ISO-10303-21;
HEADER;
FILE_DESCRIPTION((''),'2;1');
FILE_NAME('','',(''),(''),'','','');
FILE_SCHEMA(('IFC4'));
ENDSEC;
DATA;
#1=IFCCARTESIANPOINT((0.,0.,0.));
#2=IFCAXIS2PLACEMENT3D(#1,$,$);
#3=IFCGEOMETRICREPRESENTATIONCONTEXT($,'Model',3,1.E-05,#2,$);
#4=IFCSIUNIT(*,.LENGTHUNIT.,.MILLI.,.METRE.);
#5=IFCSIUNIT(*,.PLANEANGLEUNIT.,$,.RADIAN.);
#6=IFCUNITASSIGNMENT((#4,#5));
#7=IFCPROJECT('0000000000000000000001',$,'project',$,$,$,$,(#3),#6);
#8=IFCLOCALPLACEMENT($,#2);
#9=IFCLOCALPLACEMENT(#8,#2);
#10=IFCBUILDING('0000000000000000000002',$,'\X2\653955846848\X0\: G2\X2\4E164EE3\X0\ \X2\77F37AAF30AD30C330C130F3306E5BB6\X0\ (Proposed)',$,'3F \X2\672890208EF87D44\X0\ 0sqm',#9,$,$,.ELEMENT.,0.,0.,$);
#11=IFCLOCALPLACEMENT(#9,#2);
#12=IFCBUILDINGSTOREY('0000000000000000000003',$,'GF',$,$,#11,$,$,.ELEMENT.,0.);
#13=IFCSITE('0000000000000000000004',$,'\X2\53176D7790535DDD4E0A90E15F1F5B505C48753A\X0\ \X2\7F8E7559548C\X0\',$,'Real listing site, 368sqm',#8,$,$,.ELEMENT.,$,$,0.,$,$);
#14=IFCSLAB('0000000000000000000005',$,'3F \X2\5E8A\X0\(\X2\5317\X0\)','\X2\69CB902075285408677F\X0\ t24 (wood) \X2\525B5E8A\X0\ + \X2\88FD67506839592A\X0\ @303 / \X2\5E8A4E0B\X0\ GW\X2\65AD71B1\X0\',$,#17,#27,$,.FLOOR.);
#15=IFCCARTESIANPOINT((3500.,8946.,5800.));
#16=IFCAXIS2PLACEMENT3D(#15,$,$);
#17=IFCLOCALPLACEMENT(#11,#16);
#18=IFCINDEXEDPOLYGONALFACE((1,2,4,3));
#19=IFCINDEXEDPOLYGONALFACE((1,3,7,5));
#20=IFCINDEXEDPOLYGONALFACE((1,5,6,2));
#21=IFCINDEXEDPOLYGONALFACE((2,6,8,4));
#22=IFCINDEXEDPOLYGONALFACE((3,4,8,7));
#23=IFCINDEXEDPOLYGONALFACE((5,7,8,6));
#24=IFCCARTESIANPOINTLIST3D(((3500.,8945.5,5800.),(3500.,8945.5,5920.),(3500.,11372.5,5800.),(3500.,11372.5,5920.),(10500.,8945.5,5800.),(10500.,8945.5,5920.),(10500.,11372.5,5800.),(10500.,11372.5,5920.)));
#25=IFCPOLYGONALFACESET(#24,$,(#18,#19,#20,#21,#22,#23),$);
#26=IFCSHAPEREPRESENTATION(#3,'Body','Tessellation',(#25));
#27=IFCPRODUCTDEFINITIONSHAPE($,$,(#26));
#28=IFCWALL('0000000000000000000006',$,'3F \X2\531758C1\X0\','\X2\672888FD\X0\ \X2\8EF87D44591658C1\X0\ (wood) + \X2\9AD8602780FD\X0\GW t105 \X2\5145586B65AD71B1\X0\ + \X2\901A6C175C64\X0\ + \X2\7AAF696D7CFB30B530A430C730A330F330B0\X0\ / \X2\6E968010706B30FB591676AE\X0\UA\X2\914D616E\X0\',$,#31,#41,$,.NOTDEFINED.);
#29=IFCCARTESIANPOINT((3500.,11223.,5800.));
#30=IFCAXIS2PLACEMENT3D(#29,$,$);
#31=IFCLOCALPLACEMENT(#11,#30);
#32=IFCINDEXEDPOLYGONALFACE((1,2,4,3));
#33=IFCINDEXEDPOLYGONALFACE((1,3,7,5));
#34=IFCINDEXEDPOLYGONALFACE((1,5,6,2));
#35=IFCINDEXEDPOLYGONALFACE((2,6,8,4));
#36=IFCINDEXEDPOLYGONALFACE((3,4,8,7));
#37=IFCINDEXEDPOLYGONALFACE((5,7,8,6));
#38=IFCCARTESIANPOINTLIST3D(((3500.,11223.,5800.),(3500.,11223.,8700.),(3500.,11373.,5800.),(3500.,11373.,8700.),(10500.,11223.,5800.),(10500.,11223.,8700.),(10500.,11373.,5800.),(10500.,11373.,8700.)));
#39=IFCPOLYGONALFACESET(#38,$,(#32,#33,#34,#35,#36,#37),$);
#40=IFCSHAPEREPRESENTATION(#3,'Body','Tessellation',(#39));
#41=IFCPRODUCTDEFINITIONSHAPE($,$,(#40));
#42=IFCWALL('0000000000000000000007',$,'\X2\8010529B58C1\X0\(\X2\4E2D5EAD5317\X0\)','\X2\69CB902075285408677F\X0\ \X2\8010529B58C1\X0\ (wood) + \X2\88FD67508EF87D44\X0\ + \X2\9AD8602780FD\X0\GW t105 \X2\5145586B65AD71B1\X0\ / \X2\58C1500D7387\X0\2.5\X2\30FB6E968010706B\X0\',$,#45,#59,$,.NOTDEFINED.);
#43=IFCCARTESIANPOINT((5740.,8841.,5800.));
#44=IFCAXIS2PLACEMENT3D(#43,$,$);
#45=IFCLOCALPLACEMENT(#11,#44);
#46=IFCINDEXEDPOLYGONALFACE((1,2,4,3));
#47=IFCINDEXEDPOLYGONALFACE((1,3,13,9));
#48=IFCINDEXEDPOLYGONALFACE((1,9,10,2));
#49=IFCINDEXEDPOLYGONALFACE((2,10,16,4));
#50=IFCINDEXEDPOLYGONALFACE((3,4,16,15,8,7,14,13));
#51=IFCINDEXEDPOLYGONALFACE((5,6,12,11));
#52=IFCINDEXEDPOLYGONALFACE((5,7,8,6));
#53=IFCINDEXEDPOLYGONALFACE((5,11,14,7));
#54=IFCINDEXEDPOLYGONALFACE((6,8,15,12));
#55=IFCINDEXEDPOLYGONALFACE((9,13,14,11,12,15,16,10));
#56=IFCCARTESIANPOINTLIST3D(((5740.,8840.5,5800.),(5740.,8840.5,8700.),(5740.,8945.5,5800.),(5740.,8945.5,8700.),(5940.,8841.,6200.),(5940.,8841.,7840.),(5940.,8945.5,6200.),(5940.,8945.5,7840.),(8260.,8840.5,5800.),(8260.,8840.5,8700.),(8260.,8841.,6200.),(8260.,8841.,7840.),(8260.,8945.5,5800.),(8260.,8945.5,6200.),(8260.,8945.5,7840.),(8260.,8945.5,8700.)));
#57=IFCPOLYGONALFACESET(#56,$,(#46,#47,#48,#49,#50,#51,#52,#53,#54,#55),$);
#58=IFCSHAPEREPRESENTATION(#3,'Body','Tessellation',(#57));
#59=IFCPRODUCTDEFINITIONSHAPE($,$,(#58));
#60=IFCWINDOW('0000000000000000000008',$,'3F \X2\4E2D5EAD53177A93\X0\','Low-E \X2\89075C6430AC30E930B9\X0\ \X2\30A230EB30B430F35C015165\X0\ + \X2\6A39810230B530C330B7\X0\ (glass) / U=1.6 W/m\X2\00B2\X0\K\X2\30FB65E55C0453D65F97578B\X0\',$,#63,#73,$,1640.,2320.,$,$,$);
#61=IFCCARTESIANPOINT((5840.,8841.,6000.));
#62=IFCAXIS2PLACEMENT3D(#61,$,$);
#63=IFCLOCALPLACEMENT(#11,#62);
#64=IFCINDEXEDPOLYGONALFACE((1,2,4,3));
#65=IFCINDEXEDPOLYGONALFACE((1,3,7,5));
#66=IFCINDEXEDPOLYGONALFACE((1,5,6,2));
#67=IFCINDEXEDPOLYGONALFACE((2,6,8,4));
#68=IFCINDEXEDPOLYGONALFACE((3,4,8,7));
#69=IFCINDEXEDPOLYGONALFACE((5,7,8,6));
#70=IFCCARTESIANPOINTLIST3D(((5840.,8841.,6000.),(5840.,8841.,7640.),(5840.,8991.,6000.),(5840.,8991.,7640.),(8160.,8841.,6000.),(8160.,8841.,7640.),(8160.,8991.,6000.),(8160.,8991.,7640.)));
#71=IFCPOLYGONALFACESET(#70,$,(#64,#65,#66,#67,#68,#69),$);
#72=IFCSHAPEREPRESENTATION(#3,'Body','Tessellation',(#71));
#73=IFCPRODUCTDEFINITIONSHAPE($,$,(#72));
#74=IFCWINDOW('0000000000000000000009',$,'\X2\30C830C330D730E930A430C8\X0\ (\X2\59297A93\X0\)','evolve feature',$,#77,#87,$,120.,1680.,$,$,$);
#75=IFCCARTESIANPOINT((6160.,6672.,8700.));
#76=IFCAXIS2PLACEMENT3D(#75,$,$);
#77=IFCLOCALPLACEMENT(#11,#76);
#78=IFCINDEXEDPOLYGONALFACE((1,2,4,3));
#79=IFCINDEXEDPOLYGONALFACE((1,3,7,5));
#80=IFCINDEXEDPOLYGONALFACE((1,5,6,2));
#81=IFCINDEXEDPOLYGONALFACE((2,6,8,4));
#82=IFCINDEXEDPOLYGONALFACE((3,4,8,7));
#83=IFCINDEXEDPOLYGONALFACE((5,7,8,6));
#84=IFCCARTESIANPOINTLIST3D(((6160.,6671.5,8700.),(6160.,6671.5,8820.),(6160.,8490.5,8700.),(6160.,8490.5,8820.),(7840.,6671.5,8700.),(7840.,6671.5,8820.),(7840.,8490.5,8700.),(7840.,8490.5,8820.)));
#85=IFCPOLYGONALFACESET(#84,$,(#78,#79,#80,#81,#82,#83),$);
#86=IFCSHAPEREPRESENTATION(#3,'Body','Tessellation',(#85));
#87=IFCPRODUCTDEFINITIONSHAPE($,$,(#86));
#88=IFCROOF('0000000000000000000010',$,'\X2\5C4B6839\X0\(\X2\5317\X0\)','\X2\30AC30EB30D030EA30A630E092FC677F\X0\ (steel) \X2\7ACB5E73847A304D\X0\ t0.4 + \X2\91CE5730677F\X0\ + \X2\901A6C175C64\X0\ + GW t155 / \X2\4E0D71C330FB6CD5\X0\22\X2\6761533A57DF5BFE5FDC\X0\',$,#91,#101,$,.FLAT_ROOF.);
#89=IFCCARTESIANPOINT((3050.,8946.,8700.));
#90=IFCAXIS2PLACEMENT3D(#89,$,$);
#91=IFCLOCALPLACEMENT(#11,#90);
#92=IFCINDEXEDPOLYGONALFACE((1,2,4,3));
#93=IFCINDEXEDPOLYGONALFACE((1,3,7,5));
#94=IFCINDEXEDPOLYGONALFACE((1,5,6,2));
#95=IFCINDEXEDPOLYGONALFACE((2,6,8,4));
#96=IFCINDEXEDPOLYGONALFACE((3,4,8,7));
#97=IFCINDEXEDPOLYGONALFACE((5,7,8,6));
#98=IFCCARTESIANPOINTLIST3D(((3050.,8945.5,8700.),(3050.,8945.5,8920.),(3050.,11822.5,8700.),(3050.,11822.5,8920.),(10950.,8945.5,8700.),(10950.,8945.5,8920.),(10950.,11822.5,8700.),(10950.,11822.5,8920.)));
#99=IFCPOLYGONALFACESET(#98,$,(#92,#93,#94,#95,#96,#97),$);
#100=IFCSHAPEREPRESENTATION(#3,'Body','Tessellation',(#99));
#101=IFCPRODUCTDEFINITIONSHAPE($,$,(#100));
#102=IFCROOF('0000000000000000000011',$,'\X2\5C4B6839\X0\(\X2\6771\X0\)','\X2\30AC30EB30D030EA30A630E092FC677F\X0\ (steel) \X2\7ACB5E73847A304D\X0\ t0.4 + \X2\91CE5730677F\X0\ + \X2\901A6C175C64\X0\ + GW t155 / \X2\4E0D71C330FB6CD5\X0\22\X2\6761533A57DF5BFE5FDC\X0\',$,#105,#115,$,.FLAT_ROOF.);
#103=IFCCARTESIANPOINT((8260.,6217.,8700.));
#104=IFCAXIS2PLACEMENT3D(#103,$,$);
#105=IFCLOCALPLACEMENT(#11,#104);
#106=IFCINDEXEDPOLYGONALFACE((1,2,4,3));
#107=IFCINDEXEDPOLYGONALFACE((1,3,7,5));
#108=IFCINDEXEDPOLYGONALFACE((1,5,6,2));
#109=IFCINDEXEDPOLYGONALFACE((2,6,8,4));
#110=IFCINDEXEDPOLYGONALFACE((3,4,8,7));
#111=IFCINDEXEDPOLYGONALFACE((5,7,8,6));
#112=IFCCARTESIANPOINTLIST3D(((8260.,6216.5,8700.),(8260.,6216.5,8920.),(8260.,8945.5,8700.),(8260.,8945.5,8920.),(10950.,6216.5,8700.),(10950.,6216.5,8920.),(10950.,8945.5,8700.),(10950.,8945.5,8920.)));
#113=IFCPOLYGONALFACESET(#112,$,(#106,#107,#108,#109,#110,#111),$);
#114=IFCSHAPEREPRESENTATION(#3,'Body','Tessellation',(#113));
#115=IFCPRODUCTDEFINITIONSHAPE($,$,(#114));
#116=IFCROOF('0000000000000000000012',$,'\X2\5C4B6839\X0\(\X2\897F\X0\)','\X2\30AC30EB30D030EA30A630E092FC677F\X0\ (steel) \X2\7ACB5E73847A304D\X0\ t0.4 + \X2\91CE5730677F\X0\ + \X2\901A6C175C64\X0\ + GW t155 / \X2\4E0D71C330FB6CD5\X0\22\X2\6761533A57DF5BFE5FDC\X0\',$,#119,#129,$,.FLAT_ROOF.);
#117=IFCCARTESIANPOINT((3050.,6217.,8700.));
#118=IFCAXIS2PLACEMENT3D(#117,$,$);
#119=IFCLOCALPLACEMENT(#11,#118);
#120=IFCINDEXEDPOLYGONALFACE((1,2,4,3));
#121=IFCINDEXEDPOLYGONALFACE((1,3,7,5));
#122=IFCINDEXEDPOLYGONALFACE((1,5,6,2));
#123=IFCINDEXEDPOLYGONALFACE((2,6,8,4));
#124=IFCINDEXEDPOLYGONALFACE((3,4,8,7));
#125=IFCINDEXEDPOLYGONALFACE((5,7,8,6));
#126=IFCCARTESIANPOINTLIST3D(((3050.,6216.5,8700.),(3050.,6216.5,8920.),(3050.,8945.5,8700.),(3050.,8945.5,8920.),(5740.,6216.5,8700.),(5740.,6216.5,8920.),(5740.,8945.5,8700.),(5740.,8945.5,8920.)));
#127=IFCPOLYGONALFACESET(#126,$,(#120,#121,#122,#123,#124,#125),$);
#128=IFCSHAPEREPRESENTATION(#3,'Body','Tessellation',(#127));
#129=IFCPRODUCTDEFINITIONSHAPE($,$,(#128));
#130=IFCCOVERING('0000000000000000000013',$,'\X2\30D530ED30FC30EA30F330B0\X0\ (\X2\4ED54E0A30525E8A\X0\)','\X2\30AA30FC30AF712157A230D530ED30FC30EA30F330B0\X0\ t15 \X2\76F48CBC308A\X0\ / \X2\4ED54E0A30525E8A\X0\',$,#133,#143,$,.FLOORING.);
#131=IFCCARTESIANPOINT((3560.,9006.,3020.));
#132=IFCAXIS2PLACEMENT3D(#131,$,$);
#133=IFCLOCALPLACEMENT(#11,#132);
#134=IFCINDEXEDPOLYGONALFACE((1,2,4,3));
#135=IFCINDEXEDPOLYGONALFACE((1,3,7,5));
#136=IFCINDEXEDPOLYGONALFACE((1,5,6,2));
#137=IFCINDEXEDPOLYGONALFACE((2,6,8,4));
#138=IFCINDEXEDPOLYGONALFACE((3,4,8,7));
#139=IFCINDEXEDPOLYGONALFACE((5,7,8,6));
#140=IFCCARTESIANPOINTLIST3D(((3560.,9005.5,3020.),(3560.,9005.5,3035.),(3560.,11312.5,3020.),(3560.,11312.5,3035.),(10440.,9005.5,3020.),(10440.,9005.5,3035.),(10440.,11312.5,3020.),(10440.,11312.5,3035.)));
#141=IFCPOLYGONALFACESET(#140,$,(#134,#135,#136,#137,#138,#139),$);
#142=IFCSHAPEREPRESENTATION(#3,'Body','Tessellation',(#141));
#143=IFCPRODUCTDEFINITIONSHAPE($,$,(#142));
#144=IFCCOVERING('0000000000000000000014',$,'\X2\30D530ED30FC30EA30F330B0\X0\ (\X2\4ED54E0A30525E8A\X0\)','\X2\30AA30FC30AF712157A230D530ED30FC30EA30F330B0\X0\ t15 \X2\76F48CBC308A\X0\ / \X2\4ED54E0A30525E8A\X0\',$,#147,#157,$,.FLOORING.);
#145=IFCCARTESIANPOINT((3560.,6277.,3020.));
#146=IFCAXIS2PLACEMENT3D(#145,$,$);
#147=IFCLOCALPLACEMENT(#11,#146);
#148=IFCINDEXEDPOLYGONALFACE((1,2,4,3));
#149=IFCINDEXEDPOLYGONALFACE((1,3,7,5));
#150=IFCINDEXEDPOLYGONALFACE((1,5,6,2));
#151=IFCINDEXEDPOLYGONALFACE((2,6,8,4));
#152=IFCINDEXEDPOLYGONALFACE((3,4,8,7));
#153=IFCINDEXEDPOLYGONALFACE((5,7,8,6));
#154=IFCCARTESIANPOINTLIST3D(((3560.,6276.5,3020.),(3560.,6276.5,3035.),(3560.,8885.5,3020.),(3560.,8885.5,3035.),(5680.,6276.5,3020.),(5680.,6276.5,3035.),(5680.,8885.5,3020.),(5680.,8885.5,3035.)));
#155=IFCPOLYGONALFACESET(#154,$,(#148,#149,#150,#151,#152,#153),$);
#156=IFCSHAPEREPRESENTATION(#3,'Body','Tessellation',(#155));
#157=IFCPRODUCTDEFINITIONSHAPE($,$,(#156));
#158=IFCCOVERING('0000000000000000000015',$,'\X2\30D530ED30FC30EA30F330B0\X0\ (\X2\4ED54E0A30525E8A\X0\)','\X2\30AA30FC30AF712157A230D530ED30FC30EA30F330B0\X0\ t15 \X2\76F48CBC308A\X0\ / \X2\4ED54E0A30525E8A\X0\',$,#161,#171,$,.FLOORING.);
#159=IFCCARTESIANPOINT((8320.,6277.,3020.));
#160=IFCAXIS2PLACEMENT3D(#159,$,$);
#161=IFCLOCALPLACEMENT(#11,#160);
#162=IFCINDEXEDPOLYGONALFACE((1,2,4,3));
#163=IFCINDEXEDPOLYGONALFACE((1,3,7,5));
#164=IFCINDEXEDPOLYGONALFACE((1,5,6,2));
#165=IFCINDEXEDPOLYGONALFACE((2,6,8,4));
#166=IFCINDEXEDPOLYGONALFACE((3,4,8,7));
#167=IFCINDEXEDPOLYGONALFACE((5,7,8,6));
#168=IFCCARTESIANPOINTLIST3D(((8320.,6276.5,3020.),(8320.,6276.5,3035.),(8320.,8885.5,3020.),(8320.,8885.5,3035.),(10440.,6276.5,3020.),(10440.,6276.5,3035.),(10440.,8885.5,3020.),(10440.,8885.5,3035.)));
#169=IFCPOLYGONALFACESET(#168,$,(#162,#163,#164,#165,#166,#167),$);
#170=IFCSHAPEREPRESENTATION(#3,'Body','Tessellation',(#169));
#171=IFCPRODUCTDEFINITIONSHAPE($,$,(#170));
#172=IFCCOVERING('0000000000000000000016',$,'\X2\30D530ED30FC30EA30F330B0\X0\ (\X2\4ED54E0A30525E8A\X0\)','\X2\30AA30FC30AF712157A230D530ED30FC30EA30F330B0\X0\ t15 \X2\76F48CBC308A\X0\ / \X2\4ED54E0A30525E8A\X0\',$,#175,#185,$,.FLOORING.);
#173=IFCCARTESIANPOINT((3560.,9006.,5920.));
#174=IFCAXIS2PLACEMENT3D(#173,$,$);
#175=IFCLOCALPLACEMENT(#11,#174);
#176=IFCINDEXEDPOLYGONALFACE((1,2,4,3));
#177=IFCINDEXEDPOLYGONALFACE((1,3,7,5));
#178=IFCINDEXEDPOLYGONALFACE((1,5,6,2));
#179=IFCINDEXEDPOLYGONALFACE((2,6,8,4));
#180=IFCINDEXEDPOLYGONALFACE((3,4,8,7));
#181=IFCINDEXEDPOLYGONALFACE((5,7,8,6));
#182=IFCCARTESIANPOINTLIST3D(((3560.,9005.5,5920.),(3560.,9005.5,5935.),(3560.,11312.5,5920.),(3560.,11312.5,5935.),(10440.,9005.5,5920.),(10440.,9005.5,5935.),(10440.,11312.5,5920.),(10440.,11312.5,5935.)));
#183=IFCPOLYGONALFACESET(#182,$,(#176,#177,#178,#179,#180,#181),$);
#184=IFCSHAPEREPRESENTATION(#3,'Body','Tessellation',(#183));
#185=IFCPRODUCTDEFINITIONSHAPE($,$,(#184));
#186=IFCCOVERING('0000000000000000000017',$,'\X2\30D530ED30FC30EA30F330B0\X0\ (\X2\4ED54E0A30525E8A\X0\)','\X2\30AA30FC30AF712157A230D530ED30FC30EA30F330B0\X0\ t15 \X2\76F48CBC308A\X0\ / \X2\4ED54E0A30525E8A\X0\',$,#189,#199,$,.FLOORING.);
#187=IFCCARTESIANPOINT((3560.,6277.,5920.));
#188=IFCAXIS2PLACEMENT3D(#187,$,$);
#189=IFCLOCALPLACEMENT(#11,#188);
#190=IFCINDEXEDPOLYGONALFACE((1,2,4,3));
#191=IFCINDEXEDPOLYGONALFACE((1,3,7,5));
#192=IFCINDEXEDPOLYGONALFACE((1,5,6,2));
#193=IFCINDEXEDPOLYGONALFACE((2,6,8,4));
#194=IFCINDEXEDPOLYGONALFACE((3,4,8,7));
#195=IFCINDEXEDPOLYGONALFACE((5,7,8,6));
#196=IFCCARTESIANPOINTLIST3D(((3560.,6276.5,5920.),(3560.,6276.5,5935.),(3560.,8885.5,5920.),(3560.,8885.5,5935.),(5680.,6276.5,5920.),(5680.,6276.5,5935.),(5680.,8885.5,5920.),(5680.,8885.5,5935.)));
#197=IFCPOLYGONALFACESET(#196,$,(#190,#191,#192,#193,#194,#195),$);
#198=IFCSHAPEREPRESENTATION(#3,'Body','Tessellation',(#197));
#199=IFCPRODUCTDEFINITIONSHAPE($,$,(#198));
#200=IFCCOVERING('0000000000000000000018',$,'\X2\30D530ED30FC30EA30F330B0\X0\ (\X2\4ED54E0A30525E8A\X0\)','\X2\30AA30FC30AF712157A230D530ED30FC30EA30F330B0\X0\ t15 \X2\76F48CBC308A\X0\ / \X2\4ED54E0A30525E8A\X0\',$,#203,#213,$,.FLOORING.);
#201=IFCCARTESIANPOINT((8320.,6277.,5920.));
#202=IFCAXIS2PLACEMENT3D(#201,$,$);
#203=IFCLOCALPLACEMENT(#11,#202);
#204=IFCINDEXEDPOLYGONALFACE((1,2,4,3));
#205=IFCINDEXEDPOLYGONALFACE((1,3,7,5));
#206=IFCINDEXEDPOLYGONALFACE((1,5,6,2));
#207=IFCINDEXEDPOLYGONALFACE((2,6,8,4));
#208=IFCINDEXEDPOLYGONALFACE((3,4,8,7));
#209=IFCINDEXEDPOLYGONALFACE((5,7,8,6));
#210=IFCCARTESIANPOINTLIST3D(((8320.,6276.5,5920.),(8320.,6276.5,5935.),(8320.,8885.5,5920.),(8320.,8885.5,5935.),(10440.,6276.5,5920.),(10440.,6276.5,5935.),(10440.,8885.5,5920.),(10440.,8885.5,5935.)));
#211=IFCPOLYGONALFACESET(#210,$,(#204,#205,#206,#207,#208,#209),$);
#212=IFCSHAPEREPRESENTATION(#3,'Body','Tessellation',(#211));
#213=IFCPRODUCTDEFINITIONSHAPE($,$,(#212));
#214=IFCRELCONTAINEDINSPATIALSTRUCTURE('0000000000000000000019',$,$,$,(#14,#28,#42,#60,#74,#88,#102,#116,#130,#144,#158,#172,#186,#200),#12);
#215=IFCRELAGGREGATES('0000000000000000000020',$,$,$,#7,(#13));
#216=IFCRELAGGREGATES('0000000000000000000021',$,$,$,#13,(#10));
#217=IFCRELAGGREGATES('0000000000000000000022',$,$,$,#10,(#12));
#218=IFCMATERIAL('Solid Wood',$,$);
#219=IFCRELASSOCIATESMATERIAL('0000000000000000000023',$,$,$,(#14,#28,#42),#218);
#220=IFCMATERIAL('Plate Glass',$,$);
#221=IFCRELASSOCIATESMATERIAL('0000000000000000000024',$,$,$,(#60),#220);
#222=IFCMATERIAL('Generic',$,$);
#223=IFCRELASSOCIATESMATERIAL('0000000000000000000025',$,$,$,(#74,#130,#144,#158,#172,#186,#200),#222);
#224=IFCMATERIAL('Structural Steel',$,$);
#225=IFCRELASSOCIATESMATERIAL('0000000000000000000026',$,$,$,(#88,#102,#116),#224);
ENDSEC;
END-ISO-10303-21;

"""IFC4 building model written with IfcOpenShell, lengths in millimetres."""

from ifc_helpers import new_model, si_unit, frame, frame_2d, origin, place, context, project, spatial, rectangle, extrude, material, element, fill, save


model = new_model("IFC4")

# Units and contexts
model_context = context("Model", 3, precision=1e-05, world=origin())
ifc_project = project(units=[si_unit("LENGTHUNIT", "METRE", prefix="MILLI"), si_unit("PLANEANGLEUNIT", "RADIAN")], contexts=[model_context])

# Site, building, storey
site_placement = place(None, origin())
site = spatial("IfcSite", under=ifc_project, at=site_placement, Name="北海道川上郡弟子屈町 美留和", ObjectType="Real listing site, 368sqm", CompositionType="ELEMENT", RefElevation=0.0)
building_placement = place(site_placement, origin())
building = spatial("IfcBuilding", under=site, at=building_placement, Name="改善案: G2世代 石窯キッチンの家 (Proposed)", ObjectType="3F 木造軸組 0sqm", CompositionType="ELEMENT", ElevationOfRefHeight=0.0, ElevationOfTerrain=0.0)
storey_placement = place(building_placement, origin())
storey = spatial("IfcBuildingStorey", under=building, at=storey_placement, Name="GF", CompositionType="ELEMENT", Elevation=0.0)

# Slab
ifc_material_1 = material(Name="Solid Wood")
slab_placement = place(storey_placement, frame((3500.0, 8946.0, 5800.0)))
element("IfcSlab", 1, at=slab_placement, inside=storey, material=ifc_material_1, Name="3F 床(北)", Description="構造用合板 t24 (wood) 剛床 + 製材根太 @303 / 床下 GW断熱", PredefinedType="FLOOR", context=model_context, shape_type="SweptSolid", body=[
    extrude(rectangle(XDim=7000.0, YDim=2427.0, at=frame_2d((3500.0, 1213.0))), frame((3500.0, 8946.0, 5800.0)), (0.0, 0.0, 1.0), 120.0),
])

# Wall
wall_1_placement = place(storey_placement, frame((3500.0, 11223.0, 5800.0)))
element("IfcWall", 2, at=wall_1_placement, inside=storey, material=ifc_material_1, Name="3F 北壁", Description="木製 軸組外壁 (wood) + 高性能GW t105 充填断熱 + 通気層 + 窯業系サイディング / 準耐火・外皮UA配慮", PredefinedType="NOTDEFINED", context=model_context, shape_type="SweptSolid", body=[
    extrude(rectangle(XDim=7000.0, YDim=150.0, at=frame_2d((3500.0, 75.0))), frame((3500.0, 11223.0, 5800.0)), (0.0, 0.0, 1.0), 2900.0),
])

# Wall, opening, window
wall_2_placement = place(storey_placement, frame((5740.0, 8841.0, 5800.0)))
wall_2 = element("IfcWall", 3, at=wall_2_placement, inside=storey, material=ifc_material_1, Name="耐力壁(中庭北)", Description="構造用合板 耐力壁 (wood) + 製材軸組 + 高性能GW t105 充填断熱 / 壁倍率2.5・準耐火", PredefinedType="NOTDEFINED", context=model_context, shape_type="SweptSolid", body=[
    extrude(rectangle(XDim=2520.0, YDim=105.0, at=frame_2d((1260.0, 52.0))), frame((5740.0, 8841.0, 5800.0)), (0.0, 0.0, 1.0), 2900.0),
])
opening_placement = place(storey_placement, frame((5840.0, 8841.0, 6000.0)))
opening = element("IfcOpeningElement", 4, at=opening_placement, cuts=wall_2, PredefinedType="NOTDEFINED", context=model_context, shape_type="SweptSolid", body=[
    extrude(rectangle(XDim=2320.0, YDim=150.0, at=frame_2d((1160.0, 75.0))), frame((5840.0, 8841.0, 6000.0)), (0.0, 0.0, 1.0), 1640.0),
])
ifc_material_2 = material(Name="Plate Glass")
window_1_placement = place(storey_placement, frame((5840.0, 8841.0, 6000.0)))
window_1 = element("IfcWindow", 5, at=window_1_placement, inside=storey, material=ifc_material_2, Name="3F 中庭北窓", Description="Low-E 複層ガラス アルゴン封入 + 樹脂サッシ (glass) / U=1.6 W/m²K・日射取得型", OverallHeight=1640.0, OverallWidth=2320.0, context=model_context, shape_type="SweptSolid", body=[
    extrude(rectangle(XDim=2320.0, YDim=150.0, at=frame_2d((1160.0, 75.0))), frame((5840.0, 8841.0, 6000.0)), (0.0, 0.0, 1.0), 1640.0),
])
fill(opening, window_1)

# Window
ifc_material_3 = material(Name="Generic")
window_2_placement = place(storey_placement, frame((6160.0, 6672.0, 8700.0)))
element("IfcWindow", 6, at=window_2_placement, inside=storey, material=ifc_material_3, Name="トップライト (天窓)", Description="evolve feature", OverallHeight=120.0, OverallWidth=1680.0, context=model_context, shape_type="SweptSolid", body=[
    extrude(rectangle(XDim=1680.0, YDim=1819.0, at=frame_2d((840.0, 909.0))), frame((6160.0, 6672.0, 8700.0)), (0.0, 0.0, 1.0), 120.0),
])

# Roofs
ifc_material_4 = material(Name="Structural Steel")
roof_1_placement = place(storey_placement, frame((3050.0, 8946.0, 8700.0)))
element("IfcRoof", 7, at=roof_1_placement, inside=storey, material=ifc_material_4, Name="屋根(北)", Description="ガルバリウム鋼板 (steel) 立平葺き t0.4 + 野地板 + 通気層 + GW t155 / 不燃・法22条区域対応", PredefinedType="FLAT_ROOF", context=model_context, shape_type="SweptSolid", body=[
    extrude(rectangle(XDim=7900.0, YDim=2877.0, at=frame_2d((3950.0, 1438.0))), frame((3050.0, 8946.0, 8700.0)), (0.0, 0.0, 1.0), 220.0),
])
roof_2_placement = place(storey_placement, frame((8260.0, 6217.0, 8700.0)))
element("IfcRoof", 8, at=roof_2_placement, inside=storey, material=ifc_material_4, Name="屋根(東)", Description="ガルバリウム鋼板 (steel) 立平葺き t0.4 + 野地板 + 通気層 + GW t155 / 不燃・法22条区域対応", PredefinedType="FLAT_ROOF", context=model_context, shape_type="SweptSolid", body=[
    extrude(rectangle(XDim=2690.0, YDim=2729.0, at=frame_2d((1345.0, 1364.0))), frame((8260.0, 6217.0, 8700.0)), (0.0, 0.0, 1.0), 220.0),
])
roof_3_placement = place(storey_placement, frame((3050.0, 6217.0, 8700.0)))
element("IfcRoof", 9, at=roof_3_placement, inside=storey, material=ifc_material_4, Name="屋根(西)", Description="ガルバリウム鋼板 (steel) 立平葺き t0.4 + 野地板 + 通気層 + GW t155 / 不燃・法22条区域対応", PredefinedType="FLAT_ROOF", context=model_context, shape_type="SweptSolid", body=[
    extrude(rectangle(XDim=2690.0, YDim=2729.0, at=frame_2d((1345.0, 1364.0))), frame((3050.0, 6217.0, 8700.0)), (0.0, 0.0, 1.0), 220.0),
])

# Coverings
covering_1_placement = place(storey_placement, frame((3560.0, 9006.0, 3020.0)))
element("IfcCovering", 10, at=covering_1_placement, inside=storey, material=ifc_material_3, Name="フローリング (仕上げ床)", Description="オーク無垢フローリング t15 直貼り / 仕上げ床", PredefinedType="FLOORING", context=model_context, shape_type="SweptSolid", body=[
    extrude(rectangle(XDim=6880.0, YDim=2307.0, at=frame_2d((3440.0, 1153.0))), frame((3560.0, 9006.0, 3020.0)), (0.0, 0.0, 1.0), 15.0),
])
covering_2_placement = place(storey_placement, frame((3560.0, 6277.0, 3020.0)))
element("IfcCovering", 11, at=covering_2_placement, inside=storey, material=ifc_material_3, Name="フローリング (仕上げ床)", Description="オーク無垢フローリング t15 直貼り / 仕上げ床", PredefinedType="FLOORING", context=model_context, shape_type="SweptSolid", body=[
    extrude(rectangle(XDim=2120.0, YDim=2609.0, at=frame_2d((1060.0, 1304.0))), frame((3560.0, 6277.0, 3020.0)), (0.0, 0.0, 1.0), 15.0),
])
covering_3_placement = place(storey_placement, frame((8320.0, 6277.0, 3020.0)))
element("IfcCovering", 12, at=covering_3_placement, inside=storey, material=ifc_material_3, Name="フローリング (仕上げ床)", Description="オーク無垢フローリング t15 直貼り / 仕上げ床", PredefinedType="FLOORING", context=model_context, shape_type="SweptSolid", body=[
    extrude(rectangle(XDim=2120.0, YDim=2609.0, at=frame_2d((1060.0, 1304.0))), frame((8320.0, 6277.0, 3020.0)), (0.0, 0.0, 1.0), 15.0),
])
covering_4_placement = place(storey_placement, frame((3560.0, 9006.0, 5920.0)))
element("IfcCovering", 13, at=covering_4_placement, inside=storey, material=ifc_material_3, Name="フローリング (仕上げ床)", Description="オーク無垢フローリング t15 直貼り / 仕上げ床", PredefinedType="FLOORING", context=model_context, shape_type="SweptSolid", body=[
    extrude(rectangle(XDim=6880.0, YDim=2307.0, at=frame_2d((3440.0, 1153.0))), frame((3560.0, 9006.0, 5920.0)), (0.0, 0.0, 1.0), 15.0),
])
covering_5_placement = place(storey_placement, frame((3560.0, 6277.0, 5920.0)))
element("IfcCovering", 14, at=covering_5_placement, inside=storey, material=ifc_material_3, Name="フローリング (仕上げ床)", Description="オーク無垢フローリング t15 直貼り / 仕上げ床", PredefinedType="FLOORING", context=model_context, shape_type="SweptSolid", body=[
    extrude(rectangle(XDim=2120.0, YDim=2609.0, at=frame_2d((1060.0, 1304.0))), frame((3560.0, 6277.0, 5920.0)), (0.0, 0.0, 1.0), 15.0),
])
covering_6_placement = place(storey_placement, frame((8320.0, 6277.0, 5920.0)))
element("IfcCovering", 15, at=covering_6_placement, inside=storey, material=ifc_material_3, Name="フローリング (仕上げ床)", Description="オーク無垢フローリング t15 直貼り / 仕上げ床", PredefinedType="FLOORING", context=model_context, shape_type="SweptSolid", body=[
    extrude(rectangle(XDim=2120.0, YDim=2609.0, at=frame_2d((1060.0, 1304.0))), frame((8320.0, 6277.0, 5920.0)), (0.0, 0.0, 1.0), 15.0),
])

save(model, "model.ifc")
